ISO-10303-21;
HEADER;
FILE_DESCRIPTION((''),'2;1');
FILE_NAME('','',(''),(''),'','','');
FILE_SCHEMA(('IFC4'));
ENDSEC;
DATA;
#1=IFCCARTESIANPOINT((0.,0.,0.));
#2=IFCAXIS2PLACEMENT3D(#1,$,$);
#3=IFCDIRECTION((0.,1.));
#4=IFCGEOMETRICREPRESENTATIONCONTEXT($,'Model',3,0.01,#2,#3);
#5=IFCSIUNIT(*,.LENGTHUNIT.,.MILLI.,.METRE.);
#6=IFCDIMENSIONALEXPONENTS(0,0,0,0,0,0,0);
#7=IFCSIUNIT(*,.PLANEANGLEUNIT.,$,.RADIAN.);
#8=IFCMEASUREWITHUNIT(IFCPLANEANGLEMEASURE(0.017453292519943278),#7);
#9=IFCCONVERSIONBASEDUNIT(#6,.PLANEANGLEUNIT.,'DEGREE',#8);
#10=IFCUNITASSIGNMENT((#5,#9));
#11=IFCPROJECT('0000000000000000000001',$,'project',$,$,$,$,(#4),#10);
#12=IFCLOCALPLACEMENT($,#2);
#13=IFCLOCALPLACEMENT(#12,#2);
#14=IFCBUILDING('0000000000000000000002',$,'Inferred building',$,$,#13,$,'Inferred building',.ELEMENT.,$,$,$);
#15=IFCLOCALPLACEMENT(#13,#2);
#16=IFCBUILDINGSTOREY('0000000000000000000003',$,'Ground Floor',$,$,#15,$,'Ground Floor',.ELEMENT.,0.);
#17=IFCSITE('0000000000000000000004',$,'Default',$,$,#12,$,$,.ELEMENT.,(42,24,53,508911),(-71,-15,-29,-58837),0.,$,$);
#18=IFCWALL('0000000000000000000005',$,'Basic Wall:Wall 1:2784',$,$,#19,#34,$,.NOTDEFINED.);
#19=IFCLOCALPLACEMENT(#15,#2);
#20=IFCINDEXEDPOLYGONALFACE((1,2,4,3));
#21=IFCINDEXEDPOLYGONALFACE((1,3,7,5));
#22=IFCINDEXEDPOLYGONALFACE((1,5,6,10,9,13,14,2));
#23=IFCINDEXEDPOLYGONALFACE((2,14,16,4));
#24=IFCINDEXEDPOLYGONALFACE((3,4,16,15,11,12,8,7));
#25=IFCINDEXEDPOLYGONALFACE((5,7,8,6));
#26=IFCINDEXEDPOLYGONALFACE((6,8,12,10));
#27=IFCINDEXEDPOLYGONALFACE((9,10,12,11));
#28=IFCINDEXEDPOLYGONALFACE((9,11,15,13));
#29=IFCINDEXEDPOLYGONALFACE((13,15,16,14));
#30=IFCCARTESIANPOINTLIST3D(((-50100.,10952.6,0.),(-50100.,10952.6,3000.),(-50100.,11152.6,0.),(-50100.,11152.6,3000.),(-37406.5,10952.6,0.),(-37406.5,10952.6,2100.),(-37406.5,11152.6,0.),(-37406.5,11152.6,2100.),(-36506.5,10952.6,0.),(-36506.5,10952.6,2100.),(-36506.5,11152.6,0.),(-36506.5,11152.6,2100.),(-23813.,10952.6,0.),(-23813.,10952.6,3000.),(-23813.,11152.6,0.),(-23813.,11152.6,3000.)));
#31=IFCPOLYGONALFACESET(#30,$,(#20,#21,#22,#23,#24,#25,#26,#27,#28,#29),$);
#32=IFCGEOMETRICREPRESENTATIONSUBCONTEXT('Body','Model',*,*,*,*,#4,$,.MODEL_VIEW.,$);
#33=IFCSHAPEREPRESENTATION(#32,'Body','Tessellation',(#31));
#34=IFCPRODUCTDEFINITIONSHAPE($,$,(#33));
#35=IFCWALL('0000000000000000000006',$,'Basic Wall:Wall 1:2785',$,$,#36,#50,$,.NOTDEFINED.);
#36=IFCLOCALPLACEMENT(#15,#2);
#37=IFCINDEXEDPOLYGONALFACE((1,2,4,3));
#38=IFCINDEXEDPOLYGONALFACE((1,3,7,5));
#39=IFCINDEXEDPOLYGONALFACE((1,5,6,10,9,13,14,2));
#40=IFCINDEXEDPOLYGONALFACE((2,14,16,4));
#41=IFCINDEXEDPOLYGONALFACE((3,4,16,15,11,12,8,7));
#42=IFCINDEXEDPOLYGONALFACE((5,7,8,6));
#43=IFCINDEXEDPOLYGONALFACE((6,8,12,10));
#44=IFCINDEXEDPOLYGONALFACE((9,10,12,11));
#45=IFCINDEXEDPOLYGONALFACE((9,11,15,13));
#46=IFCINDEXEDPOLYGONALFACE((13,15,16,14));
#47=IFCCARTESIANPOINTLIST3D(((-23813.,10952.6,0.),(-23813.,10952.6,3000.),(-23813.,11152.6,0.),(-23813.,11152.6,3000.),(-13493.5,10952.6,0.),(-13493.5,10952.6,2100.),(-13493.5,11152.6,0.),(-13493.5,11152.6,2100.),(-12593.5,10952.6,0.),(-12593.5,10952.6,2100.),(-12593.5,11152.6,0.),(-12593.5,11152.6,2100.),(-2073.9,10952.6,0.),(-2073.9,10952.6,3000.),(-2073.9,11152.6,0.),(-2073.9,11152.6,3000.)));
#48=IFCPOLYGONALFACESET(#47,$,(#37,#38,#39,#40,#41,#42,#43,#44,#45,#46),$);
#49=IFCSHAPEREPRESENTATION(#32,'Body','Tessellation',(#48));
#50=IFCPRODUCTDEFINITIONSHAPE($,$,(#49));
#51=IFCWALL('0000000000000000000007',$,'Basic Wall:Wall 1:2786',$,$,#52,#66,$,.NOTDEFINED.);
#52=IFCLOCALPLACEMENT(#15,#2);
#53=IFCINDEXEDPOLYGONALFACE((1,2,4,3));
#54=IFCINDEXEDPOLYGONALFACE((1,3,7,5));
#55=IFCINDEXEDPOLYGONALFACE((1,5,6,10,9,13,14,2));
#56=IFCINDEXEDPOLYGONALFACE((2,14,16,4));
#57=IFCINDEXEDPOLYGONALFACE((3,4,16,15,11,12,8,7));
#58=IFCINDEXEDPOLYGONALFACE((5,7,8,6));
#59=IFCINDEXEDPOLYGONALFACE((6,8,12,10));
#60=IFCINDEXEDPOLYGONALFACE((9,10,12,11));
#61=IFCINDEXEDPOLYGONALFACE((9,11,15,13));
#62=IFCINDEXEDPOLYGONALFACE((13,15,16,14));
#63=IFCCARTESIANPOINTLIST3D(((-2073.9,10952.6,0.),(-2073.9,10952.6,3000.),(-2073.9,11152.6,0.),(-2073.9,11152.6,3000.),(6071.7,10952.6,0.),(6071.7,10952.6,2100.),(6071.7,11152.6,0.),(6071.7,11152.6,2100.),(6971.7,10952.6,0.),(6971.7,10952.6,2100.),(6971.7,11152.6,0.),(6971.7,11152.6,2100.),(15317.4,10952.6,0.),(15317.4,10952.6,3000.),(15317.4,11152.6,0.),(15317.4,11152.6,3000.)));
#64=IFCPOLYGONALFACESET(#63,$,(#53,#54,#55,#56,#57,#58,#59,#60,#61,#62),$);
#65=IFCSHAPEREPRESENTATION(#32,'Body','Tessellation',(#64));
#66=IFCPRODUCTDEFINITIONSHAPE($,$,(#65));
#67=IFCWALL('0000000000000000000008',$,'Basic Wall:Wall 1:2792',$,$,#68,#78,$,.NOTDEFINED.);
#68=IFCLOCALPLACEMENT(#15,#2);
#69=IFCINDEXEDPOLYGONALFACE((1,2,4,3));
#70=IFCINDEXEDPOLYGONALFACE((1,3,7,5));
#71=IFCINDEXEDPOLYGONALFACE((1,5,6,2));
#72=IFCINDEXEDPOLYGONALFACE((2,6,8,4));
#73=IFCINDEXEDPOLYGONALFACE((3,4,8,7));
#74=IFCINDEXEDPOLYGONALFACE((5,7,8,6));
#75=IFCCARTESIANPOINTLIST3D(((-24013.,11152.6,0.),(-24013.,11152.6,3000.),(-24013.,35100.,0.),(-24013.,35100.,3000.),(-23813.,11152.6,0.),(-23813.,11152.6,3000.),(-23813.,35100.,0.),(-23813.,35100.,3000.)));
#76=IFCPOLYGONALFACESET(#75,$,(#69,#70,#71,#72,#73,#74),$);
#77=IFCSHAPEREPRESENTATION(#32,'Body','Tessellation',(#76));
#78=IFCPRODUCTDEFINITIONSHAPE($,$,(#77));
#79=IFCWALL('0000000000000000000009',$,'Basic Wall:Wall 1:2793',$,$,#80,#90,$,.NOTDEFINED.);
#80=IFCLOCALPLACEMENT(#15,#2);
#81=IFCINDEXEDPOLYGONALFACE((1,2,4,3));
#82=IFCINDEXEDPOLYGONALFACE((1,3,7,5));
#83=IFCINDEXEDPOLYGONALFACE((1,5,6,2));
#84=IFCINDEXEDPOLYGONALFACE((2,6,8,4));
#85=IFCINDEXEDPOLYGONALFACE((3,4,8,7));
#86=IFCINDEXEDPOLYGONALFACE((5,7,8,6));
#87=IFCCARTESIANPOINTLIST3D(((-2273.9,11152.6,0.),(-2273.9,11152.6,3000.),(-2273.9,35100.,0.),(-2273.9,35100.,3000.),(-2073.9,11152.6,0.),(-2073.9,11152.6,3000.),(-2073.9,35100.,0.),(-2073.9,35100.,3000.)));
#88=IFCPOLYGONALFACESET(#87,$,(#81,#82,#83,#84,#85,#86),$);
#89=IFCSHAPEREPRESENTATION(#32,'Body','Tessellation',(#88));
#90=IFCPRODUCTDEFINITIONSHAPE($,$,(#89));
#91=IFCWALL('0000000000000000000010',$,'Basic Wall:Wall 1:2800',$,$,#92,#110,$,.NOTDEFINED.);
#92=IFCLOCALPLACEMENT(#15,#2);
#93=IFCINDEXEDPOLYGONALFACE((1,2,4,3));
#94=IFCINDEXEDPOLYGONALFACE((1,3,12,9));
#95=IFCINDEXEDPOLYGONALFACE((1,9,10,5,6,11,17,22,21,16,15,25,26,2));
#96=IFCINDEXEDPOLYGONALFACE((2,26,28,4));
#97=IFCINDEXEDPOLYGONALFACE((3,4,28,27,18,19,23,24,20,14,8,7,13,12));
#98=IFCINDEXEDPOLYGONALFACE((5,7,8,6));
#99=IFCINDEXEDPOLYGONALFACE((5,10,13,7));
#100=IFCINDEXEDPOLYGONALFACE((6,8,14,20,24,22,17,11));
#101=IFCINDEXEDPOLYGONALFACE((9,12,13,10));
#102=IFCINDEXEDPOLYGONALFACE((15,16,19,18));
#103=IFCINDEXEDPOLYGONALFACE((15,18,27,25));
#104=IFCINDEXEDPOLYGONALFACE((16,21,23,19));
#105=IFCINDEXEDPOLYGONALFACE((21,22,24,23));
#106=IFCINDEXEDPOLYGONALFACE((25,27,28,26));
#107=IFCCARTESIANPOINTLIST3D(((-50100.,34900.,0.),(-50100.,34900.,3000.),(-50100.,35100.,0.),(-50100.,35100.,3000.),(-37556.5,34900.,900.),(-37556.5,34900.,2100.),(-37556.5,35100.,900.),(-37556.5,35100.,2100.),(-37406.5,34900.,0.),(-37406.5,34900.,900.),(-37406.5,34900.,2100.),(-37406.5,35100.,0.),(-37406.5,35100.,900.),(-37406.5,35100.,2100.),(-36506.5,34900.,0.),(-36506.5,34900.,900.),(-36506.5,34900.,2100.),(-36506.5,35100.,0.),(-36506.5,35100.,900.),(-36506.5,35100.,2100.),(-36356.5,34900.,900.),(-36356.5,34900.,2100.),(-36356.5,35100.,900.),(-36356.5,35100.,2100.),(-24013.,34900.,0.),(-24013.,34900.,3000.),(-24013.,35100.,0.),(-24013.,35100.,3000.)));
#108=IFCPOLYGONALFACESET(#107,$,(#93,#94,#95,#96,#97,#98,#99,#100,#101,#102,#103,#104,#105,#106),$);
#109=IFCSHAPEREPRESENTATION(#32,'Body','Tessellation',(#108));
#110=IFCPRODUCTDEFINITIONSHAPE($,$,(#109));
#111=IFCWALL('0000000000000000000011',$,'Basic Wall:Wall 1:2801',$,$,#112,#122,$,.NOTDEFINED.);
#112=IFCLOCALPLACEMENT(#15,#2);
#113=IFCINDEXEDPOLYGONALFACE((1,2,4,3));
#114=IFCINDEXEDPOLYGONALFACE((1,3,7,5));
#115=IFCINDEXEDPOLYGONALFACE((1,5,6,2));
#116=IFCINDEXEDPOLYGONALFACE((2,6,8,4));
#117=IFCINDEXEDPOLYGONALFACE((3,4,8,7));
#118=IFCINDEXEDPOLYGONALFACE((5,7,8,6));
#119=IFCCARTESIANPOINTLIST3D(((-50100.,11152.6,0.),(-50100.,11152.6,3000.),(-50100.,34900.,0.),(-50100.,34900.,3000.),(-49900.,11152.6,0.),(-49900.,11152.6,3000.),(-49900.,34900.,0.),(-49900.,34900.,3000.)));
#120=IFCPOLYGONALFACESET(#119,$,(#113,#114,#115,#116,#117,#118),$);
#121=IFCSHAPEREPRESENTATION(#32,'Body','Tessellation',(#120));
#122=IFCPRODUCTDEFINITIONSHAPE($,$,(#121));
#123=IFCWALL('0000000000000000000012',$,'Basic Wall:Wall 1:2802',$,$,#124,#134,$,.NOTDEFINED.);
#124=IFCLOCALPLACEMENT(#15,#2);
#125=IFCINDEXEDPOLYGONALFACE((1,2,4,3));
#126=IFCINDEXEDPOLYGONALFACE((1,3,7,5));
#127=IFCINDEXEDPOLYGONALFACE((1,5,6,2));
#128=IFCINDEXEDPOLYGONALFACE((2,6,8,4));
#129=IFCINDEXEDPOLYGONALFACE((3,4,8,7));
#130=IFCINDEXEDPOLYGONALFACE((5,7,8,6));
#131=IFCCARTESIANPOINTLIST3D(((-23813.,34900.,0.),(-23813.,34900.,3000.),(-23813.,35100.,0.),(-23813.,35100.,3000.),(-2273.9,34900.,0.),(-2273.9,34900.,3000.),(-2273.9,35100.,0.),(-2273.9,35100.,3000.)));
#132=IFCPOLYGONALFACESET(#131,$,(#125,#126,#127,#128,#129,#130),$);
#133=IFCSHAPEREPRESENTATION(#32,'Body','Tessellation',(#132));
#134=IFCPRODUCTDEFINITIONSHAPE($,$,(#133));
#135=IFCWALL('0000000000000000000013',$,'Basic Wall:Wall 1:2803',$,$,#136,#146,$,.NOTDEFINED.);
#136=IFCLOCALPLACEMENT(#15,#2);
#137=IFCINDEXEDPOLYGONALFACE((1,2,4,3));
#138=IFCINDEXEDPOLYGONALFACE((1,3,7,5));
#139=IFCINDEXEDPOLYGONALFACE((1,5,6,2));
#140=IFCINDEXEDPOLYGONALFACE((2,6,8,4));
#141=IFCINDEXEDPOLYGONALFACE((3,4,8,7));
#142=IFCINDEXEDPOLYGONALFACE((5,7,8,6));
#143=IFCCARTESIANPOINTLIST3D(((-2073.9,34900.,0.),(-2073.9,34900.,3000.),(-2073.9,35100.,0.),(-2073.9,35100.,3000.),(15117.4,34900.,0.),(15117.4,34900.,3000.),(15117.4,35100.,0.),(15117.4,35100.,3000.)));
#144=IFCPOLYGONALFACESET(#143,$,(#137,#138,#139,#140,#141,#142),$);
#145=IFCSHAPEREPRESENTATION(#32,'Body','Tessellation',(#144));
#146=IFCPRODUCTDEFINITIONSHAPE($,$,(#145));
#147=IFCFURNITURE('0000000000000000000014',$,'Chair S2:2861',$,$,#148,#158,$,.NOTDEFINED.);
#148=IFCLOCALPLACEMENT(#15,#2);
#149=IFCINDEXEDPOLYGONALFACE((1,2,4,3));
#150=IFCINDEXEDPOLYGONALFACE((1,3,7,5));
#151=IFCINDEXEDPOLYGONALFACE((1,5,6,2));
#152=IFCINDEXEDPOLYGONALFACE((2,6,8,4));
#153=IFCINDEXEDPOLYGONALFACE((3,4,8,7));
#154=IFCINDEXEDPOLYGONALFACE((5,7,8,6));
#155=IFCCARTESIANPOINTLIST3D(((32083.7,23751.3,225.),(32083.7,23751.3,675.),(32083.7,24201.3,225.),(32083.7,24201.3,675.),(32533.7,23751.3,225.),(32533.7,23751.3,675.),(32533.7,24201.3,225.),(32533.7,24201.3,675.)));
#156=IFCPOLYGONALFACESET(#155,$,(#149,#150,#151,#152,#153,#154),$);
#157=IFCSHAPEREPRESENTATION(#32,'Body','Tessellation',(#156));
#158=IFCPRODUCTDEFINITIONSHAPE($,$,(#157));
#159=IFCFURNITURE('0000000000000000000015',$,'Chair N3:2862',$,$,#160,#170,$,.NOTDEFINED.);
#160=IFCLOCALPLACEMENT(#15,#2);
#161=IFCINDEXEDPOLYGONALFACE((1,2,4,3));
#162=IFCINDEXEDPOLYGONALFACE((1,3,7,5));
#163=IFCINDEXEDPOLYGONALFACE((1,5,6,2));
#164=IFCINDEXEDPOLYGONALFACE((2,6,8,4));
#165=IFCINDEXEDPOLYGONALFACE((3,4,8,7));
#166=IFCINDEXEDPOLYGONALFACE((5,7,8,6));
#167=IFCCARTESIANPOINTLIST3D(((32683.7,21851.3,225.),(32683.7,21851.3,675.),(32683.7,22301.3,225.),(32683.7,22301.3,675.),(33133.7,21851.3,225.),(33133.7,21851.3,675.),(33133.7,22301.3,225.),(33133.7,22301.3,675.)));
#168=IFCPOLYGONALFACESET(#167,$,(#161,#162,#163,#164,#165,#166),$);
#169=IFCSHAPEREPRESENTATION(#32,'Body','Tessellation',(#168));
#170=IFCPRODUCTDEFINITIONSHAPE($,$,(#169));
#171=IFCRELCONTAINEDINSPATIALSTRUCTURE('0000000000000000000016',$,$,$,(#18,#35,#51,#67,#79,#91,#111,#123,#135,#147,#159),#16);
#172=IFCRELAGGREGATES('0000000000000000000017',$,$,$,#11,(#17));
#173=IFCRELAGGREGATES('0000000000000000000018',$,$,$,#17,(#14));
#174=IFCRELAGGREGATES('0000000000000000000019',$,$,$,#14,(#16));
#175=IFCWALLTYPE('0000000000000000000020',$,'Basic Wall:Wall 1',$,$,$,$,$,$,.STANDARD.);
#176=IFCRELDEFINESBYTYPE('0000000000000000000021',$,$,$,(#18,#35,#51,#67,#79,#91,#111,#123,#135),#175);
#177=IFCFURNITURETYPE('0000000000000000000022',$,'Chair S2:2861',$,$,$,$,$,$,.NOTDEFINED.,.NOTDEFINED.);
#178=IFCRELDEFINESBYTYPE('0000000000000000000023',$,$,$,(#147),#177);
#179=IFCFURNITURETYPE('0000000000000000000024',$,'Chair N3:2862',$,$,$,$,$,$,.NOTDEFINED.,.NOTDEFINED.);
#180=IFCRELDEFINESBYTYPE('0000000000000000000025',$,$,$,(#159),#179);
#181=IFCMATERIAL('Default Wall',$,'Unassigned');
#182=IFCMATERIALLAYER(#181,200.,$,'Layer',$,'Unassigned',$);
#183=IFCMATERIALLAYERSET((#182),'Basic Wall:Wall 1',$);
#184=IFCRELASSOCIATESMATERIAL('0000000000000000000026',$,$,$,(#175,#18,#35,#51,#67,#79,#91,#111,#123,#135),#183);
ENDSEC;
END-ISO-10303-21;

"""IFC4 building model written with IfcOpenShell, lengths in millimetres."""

from ifc_helpers import new_model, entity, si_unit, converted_unit, direction, frame, frame_2d, origin, origin_2d_with_axis, place, context, subcontext, project, spatial, rectangle, extrude, material, layer, layer_set, layer_usage, type_object, element, save


model = new_model("IFC4")

# Units and contexts
model_context = context("Model", 3, precision=0.01, world=origin(), true_north=direction((0.0, 1.0)))
body_context = subcontext(model_context, "Body", "Model", "MODEL_VIEW")
ifc_project = project(units=[si_unit("LENGTHUNIT", "METRE", prefix="MILLI"), converted_unit("PLANEANGLEUNIT", "DEGREE", entity("IfcPlaneAngleMeasure", 0.017453292519943278), si_unit("PLANEANGLEUNIT", "RADIAN"), dimensions=[0, 0, 0, 0, 0, 0, 0])], contexts=[model_context])

# Site, building, storey
site_placement = place(None, origin())
site = spatial("IfcSite", under=ifc_project, at=site_placement, Name="Default", CompositionType="ELEMENT", RefLatitude=(42, 24, 53, 508911), RefLongitude=(-71, -15, -29, -58837), RefElevation=0.0)
building_placement = place(site_placement, origin())
building = spatial("IfcBuilding", under=site, at=building_placement, Name="Inferred building", LongName="Inferred building", CompositionType="ELEMENT")
storey_placement = place(building_placement, origin())
storey = spatial("IfcBuildingStorey", under=building, at=storey_placement, Name="Ground Floor", LongName="Ground Floor", CompositionType="ELEMENT", Elevation=0.0)

# Walls, openings
ifc_material = material(Name="Default Wall", Category="Unassigned")
ifc_layer = layer(ifc_material, 200.0, Name="Layer", Category="Unassigned")
ifc_layer_set = layer_set([ifc_layer], Name="Basic Wall:Wall 1")
ifc_layer_usage_1 = layer_usage(ifc_layer_set, "AXIS2", "NEGATIVE", 100.0)
wall_type = type_object("IfcWallType", Name="Basic Wall:Wall 1", PredefinedType="STANDARD", material=ifc_layer_set)
wall_1_placement = place(storey_placement, frame((-50100.0, 11052.6, 0.0)))
wall_1 = element("IfcWall", 1, at=wall_1_placement, inside=storey, type_object=wall_type, material=ifc_layer_usage_1, Name="Basic Wall:Wall 1:2784", PredefinedType="NOTDEFINED", context=body_context, shape_type="SweptSolid", body=[
    extrude(rectangle(XDim=26287.0, YDim=200.0, at=frame_2d((13143.5, 0.0), x_axis=(1.0, 0.0))), origin(), (0.0, 0.0, 1.0), 3000.0),
])
opening_1_placement = place(wall_1_placement, origin())
element("IfcOpeningElement", 2, at=opening_1_placement, cuts=wall_1, PredefinedType="OPENING", context=body_context, shape_type="SweptSolid", body=[
    extrude(rectangle(XDim=2100.0, YDim=900.0, at=frame_2d((0.0, 0.0), x_axis=(1.0, 0.0))), frame((13143.5, -100.0, 1050.0), z_axis=(0.0, 1.0, 0.0), x_axis=(0.0, 0.0, -1.0)), (0.0, 0.0, 1.0), 200.0),
])
ifc_layer_usage_2 = layer_usage(ifc_layer_set, "AXIS2", "NEGATIVE", 100.0)
wall_2_placement = place(storey_placement, frame((-23813.0, 11052.6, 0.0)))
wall_2 = element("IfcWall", 3, at=wall_2_placement, inside=storey, type_object=wall_type, material=ifc_layer_usage_2, Name="Basic Wall:Wall 1:2785", PredefinedType="NOTDEFINED", context=body_context, shape_type="SweptSolid", body=[
    extrude(rectangle(XDim=21739.1, YDim=200.0, at=frame_2d((10869.6, 0.0), x_axis=(1.0, 0.0))), origin(), (0.0, 0.0, 1.0), 3000.0),
])
opening_2_placement = place(wall_2_placement, origin())
element("IfcOpeningElement", 4, at=opening_2_placement, cuts=wall_2, PredefinedType="OPENING", context=body_context, shape_type="SweptSolid", body=[
    extrude(rectangle(XDim=2100.0, YDim=900.0, at=origin_2d_with_axis()), frame((10769.6, -100.0, 1050.0), z_axis=(0.0, 1.0, 0.0), x_axis=(0.0, 0.0, -1.0)), (0.0, 0.0, 1.0), 200.0),
])
ifc_layer_usage_3 = layer_usage(ifc_layer_set, "AXIS2", "NEGATIVE", 100.0)
wall_3_placement = place(storey_placement, frame((-2073.9, 11052.6, 0.0)))
wall_3 = element("IfcWall", 5, at=wall_3_placement, inside=storey, type_object=wall_type, material=ifc_layer_usage_3, Name="Basic Wall:Wall 1:2786", PredefinedType="NOTDEFINED", context=body_context, shape_type="SweptSolid", body=[
    extrude(rectangle(XDim=17391.3, YDim=200.0, at=frame_2d((8695.7, 0.0), x_axis=(1.0, 0.0))), origin(), (0.0, 0.0, 1.0), 3000.0),
])
opening_3_placement = place(wall_3_placement, origin())
element("IfcOpeningElement", 6, at=opening_3_placement, cuts=wall_3, PredefinedType="OPENING", context=body_context, shape_type="SweptSolid", body=[
    extrude(rectangle(XDim=2100.0, YDim=900.0, at=origin_2d_with_axis()), frame((8595.7, -100.0, 1050.0), z_axis=(0.0, 1.0, 0.0), x_axis=(0.0, 0.0, -1.0)), (0.0, 0.0, 1.0), 200.0),
])

# Walls
ifc_layer_usage_4 = layer_usage(ifc_layer_set, "AXIS2", "NEGATIVE", 100.0)
wall_4_placement = place(storey_placement, frame((-23913.0, 11152.6, 0.0), z_axis=(0.0, 0.0, 1.0), x_axis=(0.0, 1.0, 0.0)))
element("IfcWall", 7, at=wall_4_placement, inside=storey, type_object=wall_type, material=ifc_layer_usage_4, Name="Basic Wall:Wall 1:2792", PredefinedType="NOTDEFINED", context=body_context, shape_type="SweptSolid", body=[
    extrude(rectangle(XDim=23947.4, YDim=200.0, at=frame_2d((11973.7, 0.0), x_axis=(-1.0, 0.0))), origin(), (0.0, 0.0, 1.0), 3000.0),
])
ifc_layer_usage_5 = layer_usage(ifc_layer_set, "AXIS2", "NEGATIVE", 100.0)
wall_5_placement = place(storey_placement, frame((-2173.9, 11152.6, 0.0), z_axis=(0.0, 0.0, 1.0), x_axis=(0.0, 1.0, 0.0)))
element("IfcWall", 8, at=wall_5_placement, inside=storey, type_object=wall_type, material=ifc_layer_usage_5, Name="Basic Wall:Wall 1:2793", PredefinedType="NOTDEFINED", context=body_context, shape_type="SweptSolid", body=[
    extrude(rectangle(XDim=23947.4, YDim=200.0, at=frame_2d((11973.7, 0.0), x_axis=(-1.0, 0.0))), origin(), (0.0, 0.0, 1.0), 3000.0),
])

# Wall, openings
ifc_layer_usage_6 = layer_usage(ifc_layer_set, "AXIS2", "NEGATIVE", 100.0)
wall_6_placement = place(storey_placement, frame((-50100.0, 35000.0, 0.0)))
wall_6 = element("IfcWall", 9, at=wall_6_placement, inside=storey, type_object=wall_type, material=ifc_layer_usage_6, Name="Basic Wall:Wall 1:2800", PredefinedType="NOTDEFINED", context=body_context, shape_type="SweptSolid", body=[
    extrude(rectangle(XDim=26087.0, YDim=200.0, at=frame_2d((13043.5, 0.0), x_axis=(1.0, 0.0))), origin(), (0.0, 0.0, 1.0), 3000.0),
])
opening_4_placement = place(wall_6_placement, origin())
element("IfcOpeningElement", 10, at=opening_4_placement, cuts=wall_6, PredefinedType="OPENING", context=body_context, shape_type="SweptSolid", body=[
    extrude(rectangle(XDim=2100.0, YDim=900.0, at=frame_2d((0.0, 0.0), x_axis=(1.0, 0.0))), frame((13143.5, -100.0, 1050.0), z_axis=(0.0, 1.0, 0.0), x_axis=(0.0, 0.0, -1.0)), (0.0, 0.0, 1.0), 200.0),
])
opening_5_placement = place(wall_6_placement, origin())
element("IfcOpeningElement", 11, at=opening_5_placement, cuts=wall_6, PredefinedType="OPENING", context=body_context, shape_type="SweptSolid", body=[
    extrude(rectangle(XDim=1200.0, YDim=1200.0, at=frame_2d((0.0, 0.0), x_axis=(1.0, 0.0))), frame((13143.5, -100.0, 1500.0), z_axis=(0.0, 1.0, 0.0), x_axis=(0.0, 0.0, -1.0)), (0.0, 0.0, 1.0), 200.0),
])

# Walls
ifc_layer_usage_7 = layer_usage(ifc_layer_set, "AXIS2", "NEGATIVE", 100.0)
wall_7_placement = place(storey_placement, frame((-50000.0, 11152.6, 0.0), z_axis=(0.0, 0.0, 1.0), x_axis=(0.0, 1.0, 0.0)))
element("IfcWall", 12, at=wall_7_placement, inside=storey, type_object=wall_type, material=ifc_layer_usage_7, Name="Basic Wall:Wall 1:2801", PredefinedType="NOTDEFINED", context=body_context, shape_type="SweptSolid", body=[
    extrude(rectangle(XDim=23747.4, YDim=200.0, at=frame_2d((11873.7, 0.0), x_axis=(-1.0, 0.0))), origin(), (0.0, 0.0, 1.0), 3000.0),
])
ifc_layer_usage_8 = layer_usage(ifc_layer_set, "AXIS2", "NEGATIVE", 100.0)
wall_8_placement = place(storey_placement, frame((-23813.0, 35000.0, 0.0)))
element("IfcWall", 13, at=wall_8_placement, inside=storey, type_object=wall_type, material=ifc_layer_usage_8, Name="Basic Wall:Wall 1:2802", PredefinedType="NOTDEFINED", context=body_context, shape_type="SweptSolid", body=[
    extrude(rectangle(XDim=21539.1, YDim=200.0, at=frame_2d((10769.6, 0.0), x_axis=(-1.0, 0.0))), origin(), (0.0, 0.0, 1.0), 3000.0),
])
ifc_layer_usage_9 = layer_usage(ifc_layer_set, "AXIS2", "NEGATIVE", 100.0)
wall_9_placement = place(storey_placement, frame((-2073.9, 35000.0, 0.0)))
element("IfcWall", 14, at=wall_9_placement, inside=storey, type_object=wall_type, material=ifc_layer_usage_9, Name="Basic Wall:Wall 1:2803", PredefinedType="NOTDEFINED", context=body_context, shape_type="SweptSolid", body=[
    extrude(rectangle(XDim=17191.3, YDim=200.0, at=frame_2d((8595.7, 0.0), x_axis=(-1.0, 0.0))), origin(), (0.0, 0.0, 1.0), 3000.0),
])

# Furniture
furniture_type_1 = type_object("IfcFurnitureType", Name="Chair S2:2861", PredefinedType="NOTDEFINED")
furniture_1_placement = place(storey_placement, origin())
element("IfcFurniture", 15, at=furniture_1_placement, inside=storey, type_object=furniture_type_1, Name="Chair S2:2861", PredefinedType="NOTDEFINED", context=body_context, shape_type="SweptSolid", body=[
    extrude(rectangle(XDim=450.0, YDim=450.0, at=origin_2d_with_axis()), frame((32308.7, 23976.3, 225.0)), (0.0, 0.0, 1.0), 450.0),
])
furniture_type_2 = type_object("IfcFurnitureType", Name="Chair N3:2862", PredefinedType="NOTDEFINED")
furniture_2_placement = place(storey_placement, origin())
element("IfcFurniture", 16, at=furniture_2_placement, inside=storey, type_object=furniture_type_2, Name="Chair N3:2862", PredefinedType="NOTDEFINED", context=body_context, shape_type="SweptSolid", body=[
    extrude(rectangle(XDim=450.0, YDim=450.0, at=origin_2d_with_axis()), frame((32908.7, 22076.3, 225.0)), (0.0, 0.0, 1.0), 450.0),
])

save(model, "model.ifc")
